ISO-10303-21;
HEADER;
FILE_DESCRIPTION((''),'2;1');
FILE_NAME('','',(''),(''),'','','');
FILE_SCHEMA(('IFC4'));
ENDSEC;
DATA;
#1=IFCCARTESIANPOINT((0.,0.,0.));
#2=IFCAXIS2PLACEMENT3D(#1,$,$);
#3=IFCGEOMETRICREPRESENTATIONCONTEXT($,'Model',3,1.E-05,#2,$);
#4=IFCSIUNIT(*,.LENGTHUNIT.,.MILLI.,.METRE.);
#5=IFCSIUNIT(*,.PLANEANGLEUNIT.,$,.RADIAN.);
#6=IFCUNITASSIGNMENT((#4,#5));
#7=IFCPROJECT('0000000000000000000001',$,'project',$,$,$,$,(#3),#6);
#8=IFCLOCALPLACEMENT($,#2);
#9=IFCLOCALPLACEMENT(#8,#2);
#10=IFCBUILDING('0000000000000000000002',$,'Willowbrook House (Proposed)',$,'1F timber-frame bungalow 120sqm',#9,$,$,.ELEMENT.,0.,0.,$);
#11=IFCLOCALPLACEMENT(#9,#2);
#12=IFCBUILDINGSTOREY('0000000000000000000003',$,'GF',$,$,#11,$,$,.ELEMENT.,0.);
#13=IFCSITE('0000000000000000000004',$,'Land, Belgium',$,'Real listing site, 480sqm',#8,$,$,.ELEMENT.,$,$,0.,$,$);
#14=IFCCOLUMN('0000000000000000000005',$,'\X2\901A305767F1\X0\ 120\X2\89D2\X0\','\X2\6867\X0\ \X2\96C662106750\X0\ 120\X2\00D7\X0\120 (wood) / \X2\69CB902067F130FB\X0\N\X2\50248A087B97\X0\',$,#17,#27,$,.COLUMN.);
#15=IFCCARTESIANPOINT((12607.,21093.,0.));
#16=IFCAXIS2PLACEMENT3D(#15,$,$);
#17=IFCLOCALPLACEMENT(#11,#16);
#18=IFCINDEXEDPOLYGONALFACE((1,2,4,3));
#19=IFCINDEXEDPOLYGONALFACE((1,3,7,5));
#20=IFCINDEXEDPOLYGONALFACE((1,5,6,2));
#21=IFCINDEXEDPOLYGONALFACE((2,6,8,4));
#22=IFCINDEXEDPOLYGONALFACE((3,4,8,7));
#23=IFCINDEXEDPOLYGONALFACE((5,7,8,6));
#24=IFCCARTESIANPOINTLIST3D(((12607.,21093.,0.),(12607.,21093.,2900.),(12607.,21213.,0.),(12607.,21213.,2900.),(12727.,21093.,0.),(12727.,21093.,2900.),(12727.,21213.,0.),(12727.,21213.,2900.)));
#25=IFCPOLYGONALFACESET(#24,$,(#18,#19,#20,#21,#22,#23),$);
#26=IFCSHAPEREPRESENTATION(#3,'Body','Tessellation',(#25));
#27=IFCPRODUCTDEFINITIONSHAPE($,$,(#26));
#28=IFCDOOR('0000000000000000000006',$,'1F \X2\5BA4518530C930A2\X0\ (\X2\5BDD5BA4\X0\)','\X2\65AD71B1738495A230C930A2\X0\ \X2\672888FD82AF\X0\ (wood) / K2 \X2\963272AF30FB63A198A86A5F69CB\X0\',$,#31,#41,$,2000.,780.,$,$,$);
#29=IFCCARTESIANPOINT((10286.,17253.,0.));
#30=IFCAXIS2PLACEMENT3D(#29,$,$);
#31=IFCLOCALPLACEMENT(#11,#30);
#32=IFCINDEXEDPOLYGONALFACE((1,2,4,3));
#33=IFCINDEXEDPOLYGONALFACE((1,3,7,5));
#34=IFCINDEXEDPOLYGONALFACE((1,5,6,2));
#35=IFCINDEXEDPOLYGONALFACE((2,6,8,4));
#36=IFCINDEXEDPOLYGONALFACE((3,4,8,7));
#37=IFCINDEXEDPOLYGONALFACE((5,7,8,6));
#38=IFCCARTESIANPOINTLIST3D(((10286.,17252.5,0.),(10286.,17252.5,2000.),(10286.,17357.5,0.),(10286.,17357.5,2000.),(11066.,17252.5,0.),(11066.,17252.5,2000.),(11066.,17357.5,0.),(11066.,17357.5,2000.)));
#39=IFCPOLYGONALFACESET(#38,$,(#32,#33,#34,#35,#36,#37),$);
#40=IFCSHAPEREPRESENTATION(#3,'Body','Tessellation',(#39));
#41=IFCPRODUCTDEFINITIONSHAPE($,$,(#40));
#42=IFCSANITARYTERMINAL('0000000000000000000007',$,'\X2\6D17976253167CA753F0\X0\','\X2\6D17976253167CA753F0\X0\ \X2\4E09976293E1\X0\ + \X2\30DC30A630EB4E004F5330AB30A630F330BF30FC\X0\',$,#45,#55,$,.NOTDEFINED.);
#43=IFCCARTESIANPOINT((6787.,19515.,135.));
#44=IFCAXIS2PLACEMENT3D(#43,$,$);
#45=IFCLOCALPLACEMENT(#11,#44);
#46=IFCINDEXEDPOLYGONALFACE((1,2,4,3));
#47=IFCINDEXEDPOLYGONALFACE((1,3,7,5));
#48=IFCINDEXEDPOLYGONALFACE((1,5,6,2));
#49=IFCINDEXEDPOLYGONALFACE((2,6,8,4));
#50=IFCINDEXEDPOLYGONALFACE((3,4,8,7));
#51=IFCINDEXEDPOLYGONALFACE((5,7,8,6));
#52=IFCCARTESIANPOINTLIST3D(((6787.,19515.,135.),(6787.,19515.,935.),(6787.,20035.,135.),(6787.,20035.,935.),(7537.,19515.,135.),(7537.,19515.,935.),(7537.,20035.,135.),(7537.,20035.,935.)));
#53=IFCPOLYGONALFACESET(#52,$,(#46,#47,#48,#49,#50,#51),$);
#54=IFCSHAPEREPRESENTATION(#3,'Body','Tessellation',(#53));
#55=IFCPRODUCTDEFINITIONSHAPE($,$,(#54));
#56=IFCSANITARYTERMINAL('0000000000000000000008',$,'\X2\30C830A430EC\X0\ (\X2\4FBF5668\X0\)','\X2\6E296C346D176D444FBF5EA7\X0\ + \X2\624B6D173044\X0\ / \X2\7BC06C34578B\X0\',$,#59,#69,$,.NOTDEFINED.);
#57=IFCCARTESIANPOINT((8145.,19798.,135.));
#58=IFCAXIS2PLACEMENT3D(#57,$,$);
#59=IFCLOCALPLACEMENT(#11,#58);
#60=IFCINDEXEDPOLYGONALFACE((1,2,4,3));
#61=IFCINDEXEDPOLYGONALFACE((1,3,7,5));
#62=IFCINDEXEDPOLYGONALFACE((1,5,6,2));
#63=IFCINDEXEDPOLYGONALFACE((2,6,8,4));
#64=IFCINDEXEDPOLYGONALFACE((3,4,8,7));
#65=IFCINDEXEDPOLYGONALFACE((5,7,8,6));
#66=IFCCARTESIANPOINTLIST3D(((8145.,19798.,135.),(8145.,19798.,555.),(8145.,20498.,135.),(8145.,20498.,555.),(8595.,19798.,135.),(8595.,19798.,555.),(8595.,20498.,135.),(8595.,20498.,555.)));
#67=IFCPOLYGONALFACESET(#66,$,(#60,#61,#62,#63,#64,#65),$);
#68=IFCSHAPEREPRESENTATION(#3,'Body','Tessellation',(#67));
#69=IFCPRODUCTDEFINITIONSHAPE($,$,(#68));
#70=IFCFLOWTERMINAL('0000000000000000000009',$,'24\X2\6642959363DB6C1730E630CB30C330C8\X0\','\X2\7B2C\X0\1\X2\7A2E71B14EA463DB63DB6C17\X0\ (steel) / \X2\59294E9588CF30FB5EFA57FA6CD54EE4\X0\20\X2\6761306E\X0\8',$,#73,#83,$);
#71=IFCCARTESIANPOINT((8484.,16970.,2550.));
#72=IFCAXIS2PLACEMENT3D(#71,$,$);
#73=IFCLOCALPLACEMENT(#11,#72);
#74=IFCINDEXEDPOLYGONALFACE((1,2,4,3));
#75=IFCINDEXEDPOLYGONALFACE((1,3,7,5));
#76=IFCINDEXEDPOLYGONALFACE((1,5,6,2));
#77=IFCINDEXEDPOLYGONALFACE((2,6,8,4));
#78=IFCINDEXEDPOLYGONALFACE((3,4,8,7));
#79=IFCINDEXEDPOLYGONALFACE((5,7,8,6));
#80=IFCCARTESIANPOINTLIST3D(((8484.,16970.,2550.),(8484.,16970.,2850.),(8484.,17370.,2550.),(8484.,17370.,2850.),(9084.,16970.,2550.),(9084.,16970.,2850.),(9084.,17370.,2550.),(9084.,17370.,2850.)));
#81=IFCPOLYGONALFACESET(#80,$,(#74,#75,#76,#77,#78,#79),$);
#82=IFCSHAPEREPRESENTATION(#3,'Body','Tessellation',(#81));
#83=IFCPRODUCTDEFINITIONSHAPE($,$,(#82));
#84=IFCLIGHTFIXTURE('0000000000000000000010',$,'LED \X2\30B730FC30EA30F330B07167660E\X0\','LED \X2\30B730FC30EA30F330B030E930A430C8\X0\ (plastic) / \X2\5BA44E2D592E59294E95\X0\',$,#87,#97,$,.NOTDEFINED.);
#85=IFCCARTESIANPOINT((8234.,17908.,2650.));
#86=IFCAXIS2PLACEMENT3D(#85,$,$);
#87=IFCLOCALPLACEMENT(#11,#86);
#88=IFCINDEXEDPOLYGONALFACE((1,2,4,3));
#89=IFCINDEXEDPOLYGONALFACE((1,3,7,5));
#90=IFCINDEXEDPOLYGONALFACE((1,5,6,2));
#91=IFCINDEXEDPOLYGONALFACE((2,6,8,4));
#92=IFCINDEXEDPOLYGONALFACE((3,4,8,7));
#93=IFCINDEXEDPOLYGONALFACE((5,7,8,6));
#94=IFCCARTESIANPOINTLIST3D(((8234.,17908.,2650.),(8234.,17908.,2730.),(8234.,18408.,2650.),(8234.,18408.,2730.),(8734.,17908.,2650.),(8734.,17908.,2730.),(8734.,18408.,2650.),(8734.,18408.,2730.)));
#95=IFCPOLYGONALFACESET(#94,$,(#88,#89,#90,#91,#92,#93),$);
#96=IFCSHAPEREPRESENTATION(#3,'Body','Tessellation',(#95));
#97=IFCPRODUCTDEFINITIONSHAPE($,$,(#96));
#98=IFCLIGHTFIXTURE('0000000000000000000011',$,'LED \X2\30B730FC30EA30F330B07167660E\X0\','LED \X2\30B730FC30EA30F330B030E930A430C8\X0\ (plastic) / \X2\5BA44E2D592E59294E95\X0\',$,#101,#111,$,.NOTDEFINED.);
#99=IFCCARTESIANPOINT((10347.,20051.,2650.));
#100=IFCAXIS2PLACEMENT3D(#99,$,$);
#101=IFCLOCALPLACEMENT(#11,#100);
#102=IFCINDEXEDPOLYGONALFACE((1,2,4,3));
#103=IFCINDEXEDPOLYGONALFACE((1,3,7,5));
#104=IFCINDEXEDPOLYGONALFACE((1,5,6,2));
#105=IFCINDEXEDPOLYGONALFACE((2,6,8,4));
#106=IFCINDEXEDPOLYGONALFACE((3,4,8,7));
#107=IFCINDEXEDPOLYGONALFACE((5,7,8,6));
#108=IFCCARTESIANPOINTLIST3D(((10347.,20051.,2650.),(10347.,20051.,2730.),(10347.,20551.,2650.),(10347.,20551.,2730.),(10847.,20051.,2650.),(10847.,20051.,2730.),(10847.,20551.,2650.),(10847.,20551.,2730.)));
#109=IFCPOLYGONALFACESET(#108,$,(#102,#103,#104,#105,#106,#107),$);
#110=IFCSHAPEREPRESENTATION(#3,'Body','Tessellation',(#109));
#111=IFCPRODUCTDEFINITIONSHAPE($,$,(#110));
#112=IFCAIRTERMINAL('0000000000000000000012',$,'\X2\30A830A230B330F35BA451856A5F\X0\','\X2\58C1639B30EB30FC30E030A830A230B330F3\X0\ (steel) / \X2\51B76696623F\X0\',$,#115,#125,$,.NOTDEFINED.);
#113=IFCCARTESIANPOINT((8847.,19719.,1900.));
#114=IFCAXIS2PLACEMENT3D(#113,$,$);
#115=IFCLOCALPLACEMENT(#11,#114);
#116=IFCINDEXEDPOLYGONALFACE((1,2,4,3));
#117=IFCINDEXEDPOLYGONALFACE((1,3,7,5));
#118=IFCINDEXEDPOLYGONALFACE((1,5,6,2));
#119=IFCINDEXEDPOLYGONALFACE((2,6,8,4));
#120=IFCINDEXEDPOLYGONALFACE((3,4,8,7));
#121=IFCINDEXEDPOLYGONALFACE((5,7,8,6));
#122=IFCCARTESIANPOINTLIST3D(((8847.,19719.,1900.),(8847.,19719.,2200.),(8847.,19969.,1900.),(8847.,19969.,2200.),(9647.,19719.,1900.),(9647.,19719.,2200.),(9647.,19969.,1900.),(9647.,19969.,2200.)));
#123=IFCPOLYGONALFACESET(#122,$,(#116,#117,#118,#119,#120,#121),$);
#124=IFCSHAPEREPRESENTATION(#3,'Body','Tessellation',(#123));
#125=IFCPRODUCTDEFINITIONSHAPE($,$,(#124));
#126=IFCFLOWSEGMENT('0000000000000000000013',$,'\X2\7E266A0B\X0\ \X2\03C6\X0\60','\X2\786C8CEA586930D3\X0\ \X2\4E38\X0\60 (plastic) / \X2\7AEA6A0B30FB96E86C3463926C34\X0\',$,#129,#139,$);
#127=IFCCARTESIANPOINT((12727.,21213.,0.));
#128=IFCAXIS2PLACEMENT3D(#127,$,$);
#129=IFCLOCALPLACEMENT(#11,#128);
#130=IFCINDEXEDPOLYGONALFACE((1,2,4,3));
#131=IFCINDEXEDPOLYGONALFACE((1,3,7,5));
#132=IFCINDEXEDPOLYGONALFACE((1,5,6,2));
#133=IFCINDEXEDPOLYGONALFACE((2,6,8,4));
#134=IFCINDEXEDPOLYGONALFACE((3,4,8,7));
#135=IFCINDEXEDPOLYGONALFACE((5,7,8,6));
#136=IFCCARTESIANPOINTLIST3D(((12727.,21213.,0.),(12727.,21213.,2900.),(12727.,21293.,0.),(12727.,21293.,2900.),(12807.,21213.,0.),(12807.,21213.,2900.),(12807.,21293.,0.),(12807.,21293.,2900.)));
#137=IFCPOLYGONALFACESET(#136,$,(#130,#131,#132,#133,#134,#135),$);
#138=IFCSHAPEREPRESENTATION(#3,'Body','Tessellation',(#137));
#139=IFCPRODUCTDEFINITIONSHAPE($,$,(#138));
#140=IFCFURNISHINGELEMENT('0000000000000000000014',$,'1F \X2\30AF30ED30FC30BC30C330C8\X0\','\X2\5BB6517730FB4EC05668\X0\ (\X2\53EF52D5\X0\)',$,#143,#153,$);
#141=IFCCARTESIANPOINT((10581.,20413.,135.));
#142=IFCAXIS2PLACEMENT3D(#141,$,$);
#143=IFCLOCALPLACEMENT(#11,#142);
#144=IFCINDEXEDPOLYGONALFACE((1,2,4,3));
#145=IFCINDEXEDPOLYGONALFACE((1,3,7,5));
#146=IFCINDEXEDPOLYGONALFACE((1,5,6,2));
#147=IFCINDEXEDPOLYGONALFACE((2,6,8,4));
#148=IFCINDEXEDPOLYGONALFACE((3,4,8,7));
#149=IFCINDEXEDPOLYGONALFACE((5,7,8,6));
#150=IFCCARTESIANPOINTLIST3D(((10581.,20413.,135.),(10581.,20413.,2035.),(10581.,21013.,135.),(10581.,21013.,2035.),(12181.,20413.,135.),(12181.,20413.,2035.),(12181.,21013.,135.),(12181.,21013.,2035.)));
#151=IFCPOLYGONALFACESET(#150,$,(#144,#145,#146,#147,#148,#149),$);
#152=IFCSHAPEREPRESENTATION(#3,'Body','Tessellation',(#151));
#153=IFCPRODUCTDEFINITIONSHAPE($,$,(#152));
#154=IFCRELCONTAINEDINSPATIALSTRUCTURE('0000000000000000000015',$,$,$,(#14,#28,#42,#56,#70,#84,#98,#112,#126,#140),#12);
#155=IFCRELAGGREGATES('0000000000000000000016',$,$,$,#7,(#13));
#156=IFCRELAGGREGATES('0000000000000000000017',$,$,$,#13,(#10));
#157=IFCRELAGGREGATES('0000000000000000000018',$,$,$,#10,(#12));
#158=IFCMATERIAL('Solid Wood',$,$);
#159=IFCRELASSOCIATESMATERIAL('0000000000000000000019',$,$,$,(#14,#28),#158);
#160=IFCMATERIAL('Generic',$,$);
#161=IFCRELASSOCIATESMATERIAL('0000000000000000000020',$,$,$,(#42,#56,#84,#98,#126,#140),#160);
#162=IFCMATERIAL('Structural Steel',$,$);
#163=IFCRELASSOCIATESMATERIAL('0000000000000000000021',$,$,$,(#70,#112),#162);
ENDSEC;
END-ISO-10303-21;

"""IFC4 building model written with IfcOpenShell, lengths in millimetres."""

from ifc_helpers import new_model, si_unit, frame, frame_2d, origin, place, context, project, spatial, rectangle, extrude, material, element, save


model = new_model("IFC4")

# Units and contexts
model_context = context("Model", 3, precision=1e-05, world=origin())
ifc_project = project(units=[si_unit("LENGTHUNIT", "METRE", prefix="MILLI"), si_unit("PLANEANGLEUNIT", "RADIAN")], contexts=[model_context])

# Site, building, storey
site_placement = place(None, origin())
site = spatial("IfcSite", under=ifc_project, at=site_placement, Name="Land, Belgium", ObjectType="Real listing site, 480sqm", CompositionType="ELEMENT", RefElevation=0.0)
building_placement = place(site_placement, origin())
building = spatial("IfcBuilding", under=site, at=building_placement, Name="Willowbrook House (Proposed)", ObjectType="1F timber-frame bungalow 120sqm", CompositionType="ELEMENT", ElevationOfRefHeight=0.0, ElevationOfTerrain=0.0)
storey_placement = place(building_placement, origin())
storey = spatial("IfcBuildingStorey", under=building, at=storey_placement, Name="GF", CompositionType="ELEMENT", Elevation=0.0)

# Column
ifc_material_1 = material(Name="Solid Wood")
column_1_placement = place(storey_placement, frame((12607.0, 21093.0, 0.0)))
element("IfcColumn", 1, at=column_1_placement, inside=storey, material=ifc_material_1, Name="通し柱 120角", Description="桧 集成材 120×120 (wood) / 構造柱・N値計算", PredefinedType="COLUMN", context=model_context, shape_type="SweptSolid", body=[
    extrude(rectangle(XDim=120.0, YDim=120.0, at=frame_2d((60.0, 60.0))), frame((12607.0, 21093.0, 0.0)), (0.0, 0.0, 1.0), 2900.0),
])

# Door
door_placement = place(storey_placement, frame((10286.0, 17253.0, 0.0)))
element("IfcDoor", 2, at=door_placement, inside=storey, material=ifc_material_1, Name="1F 室内ドア (寝室)", Description="断熱玄関ドア 木製芯 (wood) / K2 防犯・採風機構", OverallHeight=2000.0, OverallWidth=780.0, context=model_context, shape_type="SweptSolid", body=[
    extrude(rectangle(XDim=780.0, YDim=105.0, at=frame_2d((390.0, 52.0))), frame((10286.0, 17253.0, 0.0)), (0.0, 0.0, 1.0), 2000.0),
])

# Sanitary terminals
ifc_material_2 = material(Name="Generic")
sanitary_terminal_1_placement = place(storey_placement, frame((6787.0, 19515.0, 135.0)))
element("IfcSanitaryTerminal", 3, at=sanitary_terminal_1_placement, inside=storey, material=ifc_material_2, Name="洗面化粧台", Description="洗面化粧台 三面鏡 + ボウル一体カウンター", PredefinedType="NOTDEFINED", context=model_context, shape_type="SweptSolid", body=[
    extrude(rectangle(XDim=750.0, YDim=520.0, at=frame_2d((375.0, 260.0))), frame((6787.0, 19515.0, 135.0)), (0.0, 0.0, 1.0), 800.0),
])
sanitary_terminal_2_placement = place(storey_placement, frame((8145.0, 19798.0, 135.0)))
element("IfcSanitaryTerminal", 4, at=sanitary_terminal_2_placement, inside=storey, material=ifc_material_2, Name="トイレ (便器)", Description="温水洗浄便座 + 手洗い / 節水型", PredefinedType="NOTDEFINED", context=model_context, shape_type="SweptSolid", body=[
    extrude(rectangle(XDim=450.0, YDim=700.0, at=frame_2d((225.0, 350.0))), frame((8145.0, 19798.0, 135.0)), (0.0, 0.0, 1.0), 420.0),
])

# Flow terminal
ifc_material_3 = material(Name="Structural Steel")
flow_terminal_placement = place(storey_placement, frame((8484.0, 16970.0, 2550.0)))
element("IfcFlowTerminal", 5, at=flow_terminal_placement, inside=storey, material=ifc_material_3, Name="24時間換気ユニット", Description="第1種熱交換換気 (steel) / 天井裏・建基法令20条の8", context=model_context, shape_type="SweptSolid", body=[
    extrude(rectangle(XDim=600.0, YDim=400.0, at=frame_2d((300.0, 200.0))), frame((8484.0, 16970.0, 2550.0)), (0.0, 0.0, 1.0), 300.0),
])

# Light fixtures
light_fixture_1_placement = place(storey_placement, frame((8234.0, 17908.0, 2650.0)))
element("IfcLightFixture", 6, at=light_fixture_1_placement, inside=storey, material=ifc_material_2, Name="LED シーリング照明", Description="LED シーリングライト (plastic) / 室中央天井", PredefinedType="NOTDEFINED", context=model_context, shape_type="SweptSolid", body=[
    extrude(rectangle(XDim=500.0, YDim=500.0, at=frame_2d((250.0, 250.0))), frame((8234.0, 17908.0, 2650.0)), (0.0, 0.0, 1.0), 80.0),
])
light_fixture_2_placement = place(storey_placement, frame((10347.0, 20051.0, 2650.0)))
element("IfcLightFixture", 7, at=light_fixture_2_placement, inside=storey, material=ifc_material_2, Name="LED シーリング照明", Description="LED シーリングライト (plastic) / 室中央天井", PredefinedType="NOTDEFINED", context=model_context, shape_type="SweptSolid", body=[
    extrude(rectangle(XDim=500.0, YDim=500.0, at=frame_2d((250.0, 250.0))), frame((10347.0, 20051.0, 2650.0)), (0.0, 0.0, 1.0), 80.0),
])

# Air terminal
air_terminal_placement = place(storey_placement, frame((8847.0, 19719.0, 1900.0)))
element("IfcAirTerminal", 8, at=air_terminal_placement, inside=storey, material=ifc_material_3, Name="エアコン室内機", Description="壁掛ルームエアコン (steel) / 冷暖房", PredefinedType="NOTDEFINED", context=model_context, shape_type="SweptSolid", body=[
    extrude(rectangle(XDim=800.0, YDim=250.0, at=frame_2d((400.0, 125.0))), frame((8847.0, 19719.0, 1900.0)), (0.0, 0.0, 1.0), 300.0),
])

# Flow segment
flow_segment_placement = place(storey_placement, frame((12727.0, 21213.0, 0.0)))
element("IfcFlowSegment", 9, at=flow_segment_placement, inside=storey, material=ifc_material_2, Name="縦樋 φ60", Description="硬質塩ビ 丸60 (plastic) / 竪樋・雨水排水", context=model_context, shape_type="SweptSolid", body=[
    extrude(rectangle(XDim=80.0, YDim=80.0, at=frame_2d((40.0, 40.0))), frame((12727.0, 21213.0, 0.0)), (0.0, 0.0, 1.0), 2900.0),
])

# Furnishing element
furnishing_placement = place(storey_placement, frame((10581.0, 20413.0, 135.0)))
element("IfcFurnishingElement", 10, at=furnishing_placement, inside=storey, material=ifc_material_2, Name="1F クローゼット", Description="家具・什器 (可動)", context=model_context, shape_type="SweptSolid", body=[
    extrude(rectangle(XDim=1600.0, YDim=600.0, at=frame_2d((800.0, 300.0))), frame((10581.0, 20413.0, 135.0)), (0.0, 0.0, 1.0), 1900.0),
])

save(model, "model.ifc")
